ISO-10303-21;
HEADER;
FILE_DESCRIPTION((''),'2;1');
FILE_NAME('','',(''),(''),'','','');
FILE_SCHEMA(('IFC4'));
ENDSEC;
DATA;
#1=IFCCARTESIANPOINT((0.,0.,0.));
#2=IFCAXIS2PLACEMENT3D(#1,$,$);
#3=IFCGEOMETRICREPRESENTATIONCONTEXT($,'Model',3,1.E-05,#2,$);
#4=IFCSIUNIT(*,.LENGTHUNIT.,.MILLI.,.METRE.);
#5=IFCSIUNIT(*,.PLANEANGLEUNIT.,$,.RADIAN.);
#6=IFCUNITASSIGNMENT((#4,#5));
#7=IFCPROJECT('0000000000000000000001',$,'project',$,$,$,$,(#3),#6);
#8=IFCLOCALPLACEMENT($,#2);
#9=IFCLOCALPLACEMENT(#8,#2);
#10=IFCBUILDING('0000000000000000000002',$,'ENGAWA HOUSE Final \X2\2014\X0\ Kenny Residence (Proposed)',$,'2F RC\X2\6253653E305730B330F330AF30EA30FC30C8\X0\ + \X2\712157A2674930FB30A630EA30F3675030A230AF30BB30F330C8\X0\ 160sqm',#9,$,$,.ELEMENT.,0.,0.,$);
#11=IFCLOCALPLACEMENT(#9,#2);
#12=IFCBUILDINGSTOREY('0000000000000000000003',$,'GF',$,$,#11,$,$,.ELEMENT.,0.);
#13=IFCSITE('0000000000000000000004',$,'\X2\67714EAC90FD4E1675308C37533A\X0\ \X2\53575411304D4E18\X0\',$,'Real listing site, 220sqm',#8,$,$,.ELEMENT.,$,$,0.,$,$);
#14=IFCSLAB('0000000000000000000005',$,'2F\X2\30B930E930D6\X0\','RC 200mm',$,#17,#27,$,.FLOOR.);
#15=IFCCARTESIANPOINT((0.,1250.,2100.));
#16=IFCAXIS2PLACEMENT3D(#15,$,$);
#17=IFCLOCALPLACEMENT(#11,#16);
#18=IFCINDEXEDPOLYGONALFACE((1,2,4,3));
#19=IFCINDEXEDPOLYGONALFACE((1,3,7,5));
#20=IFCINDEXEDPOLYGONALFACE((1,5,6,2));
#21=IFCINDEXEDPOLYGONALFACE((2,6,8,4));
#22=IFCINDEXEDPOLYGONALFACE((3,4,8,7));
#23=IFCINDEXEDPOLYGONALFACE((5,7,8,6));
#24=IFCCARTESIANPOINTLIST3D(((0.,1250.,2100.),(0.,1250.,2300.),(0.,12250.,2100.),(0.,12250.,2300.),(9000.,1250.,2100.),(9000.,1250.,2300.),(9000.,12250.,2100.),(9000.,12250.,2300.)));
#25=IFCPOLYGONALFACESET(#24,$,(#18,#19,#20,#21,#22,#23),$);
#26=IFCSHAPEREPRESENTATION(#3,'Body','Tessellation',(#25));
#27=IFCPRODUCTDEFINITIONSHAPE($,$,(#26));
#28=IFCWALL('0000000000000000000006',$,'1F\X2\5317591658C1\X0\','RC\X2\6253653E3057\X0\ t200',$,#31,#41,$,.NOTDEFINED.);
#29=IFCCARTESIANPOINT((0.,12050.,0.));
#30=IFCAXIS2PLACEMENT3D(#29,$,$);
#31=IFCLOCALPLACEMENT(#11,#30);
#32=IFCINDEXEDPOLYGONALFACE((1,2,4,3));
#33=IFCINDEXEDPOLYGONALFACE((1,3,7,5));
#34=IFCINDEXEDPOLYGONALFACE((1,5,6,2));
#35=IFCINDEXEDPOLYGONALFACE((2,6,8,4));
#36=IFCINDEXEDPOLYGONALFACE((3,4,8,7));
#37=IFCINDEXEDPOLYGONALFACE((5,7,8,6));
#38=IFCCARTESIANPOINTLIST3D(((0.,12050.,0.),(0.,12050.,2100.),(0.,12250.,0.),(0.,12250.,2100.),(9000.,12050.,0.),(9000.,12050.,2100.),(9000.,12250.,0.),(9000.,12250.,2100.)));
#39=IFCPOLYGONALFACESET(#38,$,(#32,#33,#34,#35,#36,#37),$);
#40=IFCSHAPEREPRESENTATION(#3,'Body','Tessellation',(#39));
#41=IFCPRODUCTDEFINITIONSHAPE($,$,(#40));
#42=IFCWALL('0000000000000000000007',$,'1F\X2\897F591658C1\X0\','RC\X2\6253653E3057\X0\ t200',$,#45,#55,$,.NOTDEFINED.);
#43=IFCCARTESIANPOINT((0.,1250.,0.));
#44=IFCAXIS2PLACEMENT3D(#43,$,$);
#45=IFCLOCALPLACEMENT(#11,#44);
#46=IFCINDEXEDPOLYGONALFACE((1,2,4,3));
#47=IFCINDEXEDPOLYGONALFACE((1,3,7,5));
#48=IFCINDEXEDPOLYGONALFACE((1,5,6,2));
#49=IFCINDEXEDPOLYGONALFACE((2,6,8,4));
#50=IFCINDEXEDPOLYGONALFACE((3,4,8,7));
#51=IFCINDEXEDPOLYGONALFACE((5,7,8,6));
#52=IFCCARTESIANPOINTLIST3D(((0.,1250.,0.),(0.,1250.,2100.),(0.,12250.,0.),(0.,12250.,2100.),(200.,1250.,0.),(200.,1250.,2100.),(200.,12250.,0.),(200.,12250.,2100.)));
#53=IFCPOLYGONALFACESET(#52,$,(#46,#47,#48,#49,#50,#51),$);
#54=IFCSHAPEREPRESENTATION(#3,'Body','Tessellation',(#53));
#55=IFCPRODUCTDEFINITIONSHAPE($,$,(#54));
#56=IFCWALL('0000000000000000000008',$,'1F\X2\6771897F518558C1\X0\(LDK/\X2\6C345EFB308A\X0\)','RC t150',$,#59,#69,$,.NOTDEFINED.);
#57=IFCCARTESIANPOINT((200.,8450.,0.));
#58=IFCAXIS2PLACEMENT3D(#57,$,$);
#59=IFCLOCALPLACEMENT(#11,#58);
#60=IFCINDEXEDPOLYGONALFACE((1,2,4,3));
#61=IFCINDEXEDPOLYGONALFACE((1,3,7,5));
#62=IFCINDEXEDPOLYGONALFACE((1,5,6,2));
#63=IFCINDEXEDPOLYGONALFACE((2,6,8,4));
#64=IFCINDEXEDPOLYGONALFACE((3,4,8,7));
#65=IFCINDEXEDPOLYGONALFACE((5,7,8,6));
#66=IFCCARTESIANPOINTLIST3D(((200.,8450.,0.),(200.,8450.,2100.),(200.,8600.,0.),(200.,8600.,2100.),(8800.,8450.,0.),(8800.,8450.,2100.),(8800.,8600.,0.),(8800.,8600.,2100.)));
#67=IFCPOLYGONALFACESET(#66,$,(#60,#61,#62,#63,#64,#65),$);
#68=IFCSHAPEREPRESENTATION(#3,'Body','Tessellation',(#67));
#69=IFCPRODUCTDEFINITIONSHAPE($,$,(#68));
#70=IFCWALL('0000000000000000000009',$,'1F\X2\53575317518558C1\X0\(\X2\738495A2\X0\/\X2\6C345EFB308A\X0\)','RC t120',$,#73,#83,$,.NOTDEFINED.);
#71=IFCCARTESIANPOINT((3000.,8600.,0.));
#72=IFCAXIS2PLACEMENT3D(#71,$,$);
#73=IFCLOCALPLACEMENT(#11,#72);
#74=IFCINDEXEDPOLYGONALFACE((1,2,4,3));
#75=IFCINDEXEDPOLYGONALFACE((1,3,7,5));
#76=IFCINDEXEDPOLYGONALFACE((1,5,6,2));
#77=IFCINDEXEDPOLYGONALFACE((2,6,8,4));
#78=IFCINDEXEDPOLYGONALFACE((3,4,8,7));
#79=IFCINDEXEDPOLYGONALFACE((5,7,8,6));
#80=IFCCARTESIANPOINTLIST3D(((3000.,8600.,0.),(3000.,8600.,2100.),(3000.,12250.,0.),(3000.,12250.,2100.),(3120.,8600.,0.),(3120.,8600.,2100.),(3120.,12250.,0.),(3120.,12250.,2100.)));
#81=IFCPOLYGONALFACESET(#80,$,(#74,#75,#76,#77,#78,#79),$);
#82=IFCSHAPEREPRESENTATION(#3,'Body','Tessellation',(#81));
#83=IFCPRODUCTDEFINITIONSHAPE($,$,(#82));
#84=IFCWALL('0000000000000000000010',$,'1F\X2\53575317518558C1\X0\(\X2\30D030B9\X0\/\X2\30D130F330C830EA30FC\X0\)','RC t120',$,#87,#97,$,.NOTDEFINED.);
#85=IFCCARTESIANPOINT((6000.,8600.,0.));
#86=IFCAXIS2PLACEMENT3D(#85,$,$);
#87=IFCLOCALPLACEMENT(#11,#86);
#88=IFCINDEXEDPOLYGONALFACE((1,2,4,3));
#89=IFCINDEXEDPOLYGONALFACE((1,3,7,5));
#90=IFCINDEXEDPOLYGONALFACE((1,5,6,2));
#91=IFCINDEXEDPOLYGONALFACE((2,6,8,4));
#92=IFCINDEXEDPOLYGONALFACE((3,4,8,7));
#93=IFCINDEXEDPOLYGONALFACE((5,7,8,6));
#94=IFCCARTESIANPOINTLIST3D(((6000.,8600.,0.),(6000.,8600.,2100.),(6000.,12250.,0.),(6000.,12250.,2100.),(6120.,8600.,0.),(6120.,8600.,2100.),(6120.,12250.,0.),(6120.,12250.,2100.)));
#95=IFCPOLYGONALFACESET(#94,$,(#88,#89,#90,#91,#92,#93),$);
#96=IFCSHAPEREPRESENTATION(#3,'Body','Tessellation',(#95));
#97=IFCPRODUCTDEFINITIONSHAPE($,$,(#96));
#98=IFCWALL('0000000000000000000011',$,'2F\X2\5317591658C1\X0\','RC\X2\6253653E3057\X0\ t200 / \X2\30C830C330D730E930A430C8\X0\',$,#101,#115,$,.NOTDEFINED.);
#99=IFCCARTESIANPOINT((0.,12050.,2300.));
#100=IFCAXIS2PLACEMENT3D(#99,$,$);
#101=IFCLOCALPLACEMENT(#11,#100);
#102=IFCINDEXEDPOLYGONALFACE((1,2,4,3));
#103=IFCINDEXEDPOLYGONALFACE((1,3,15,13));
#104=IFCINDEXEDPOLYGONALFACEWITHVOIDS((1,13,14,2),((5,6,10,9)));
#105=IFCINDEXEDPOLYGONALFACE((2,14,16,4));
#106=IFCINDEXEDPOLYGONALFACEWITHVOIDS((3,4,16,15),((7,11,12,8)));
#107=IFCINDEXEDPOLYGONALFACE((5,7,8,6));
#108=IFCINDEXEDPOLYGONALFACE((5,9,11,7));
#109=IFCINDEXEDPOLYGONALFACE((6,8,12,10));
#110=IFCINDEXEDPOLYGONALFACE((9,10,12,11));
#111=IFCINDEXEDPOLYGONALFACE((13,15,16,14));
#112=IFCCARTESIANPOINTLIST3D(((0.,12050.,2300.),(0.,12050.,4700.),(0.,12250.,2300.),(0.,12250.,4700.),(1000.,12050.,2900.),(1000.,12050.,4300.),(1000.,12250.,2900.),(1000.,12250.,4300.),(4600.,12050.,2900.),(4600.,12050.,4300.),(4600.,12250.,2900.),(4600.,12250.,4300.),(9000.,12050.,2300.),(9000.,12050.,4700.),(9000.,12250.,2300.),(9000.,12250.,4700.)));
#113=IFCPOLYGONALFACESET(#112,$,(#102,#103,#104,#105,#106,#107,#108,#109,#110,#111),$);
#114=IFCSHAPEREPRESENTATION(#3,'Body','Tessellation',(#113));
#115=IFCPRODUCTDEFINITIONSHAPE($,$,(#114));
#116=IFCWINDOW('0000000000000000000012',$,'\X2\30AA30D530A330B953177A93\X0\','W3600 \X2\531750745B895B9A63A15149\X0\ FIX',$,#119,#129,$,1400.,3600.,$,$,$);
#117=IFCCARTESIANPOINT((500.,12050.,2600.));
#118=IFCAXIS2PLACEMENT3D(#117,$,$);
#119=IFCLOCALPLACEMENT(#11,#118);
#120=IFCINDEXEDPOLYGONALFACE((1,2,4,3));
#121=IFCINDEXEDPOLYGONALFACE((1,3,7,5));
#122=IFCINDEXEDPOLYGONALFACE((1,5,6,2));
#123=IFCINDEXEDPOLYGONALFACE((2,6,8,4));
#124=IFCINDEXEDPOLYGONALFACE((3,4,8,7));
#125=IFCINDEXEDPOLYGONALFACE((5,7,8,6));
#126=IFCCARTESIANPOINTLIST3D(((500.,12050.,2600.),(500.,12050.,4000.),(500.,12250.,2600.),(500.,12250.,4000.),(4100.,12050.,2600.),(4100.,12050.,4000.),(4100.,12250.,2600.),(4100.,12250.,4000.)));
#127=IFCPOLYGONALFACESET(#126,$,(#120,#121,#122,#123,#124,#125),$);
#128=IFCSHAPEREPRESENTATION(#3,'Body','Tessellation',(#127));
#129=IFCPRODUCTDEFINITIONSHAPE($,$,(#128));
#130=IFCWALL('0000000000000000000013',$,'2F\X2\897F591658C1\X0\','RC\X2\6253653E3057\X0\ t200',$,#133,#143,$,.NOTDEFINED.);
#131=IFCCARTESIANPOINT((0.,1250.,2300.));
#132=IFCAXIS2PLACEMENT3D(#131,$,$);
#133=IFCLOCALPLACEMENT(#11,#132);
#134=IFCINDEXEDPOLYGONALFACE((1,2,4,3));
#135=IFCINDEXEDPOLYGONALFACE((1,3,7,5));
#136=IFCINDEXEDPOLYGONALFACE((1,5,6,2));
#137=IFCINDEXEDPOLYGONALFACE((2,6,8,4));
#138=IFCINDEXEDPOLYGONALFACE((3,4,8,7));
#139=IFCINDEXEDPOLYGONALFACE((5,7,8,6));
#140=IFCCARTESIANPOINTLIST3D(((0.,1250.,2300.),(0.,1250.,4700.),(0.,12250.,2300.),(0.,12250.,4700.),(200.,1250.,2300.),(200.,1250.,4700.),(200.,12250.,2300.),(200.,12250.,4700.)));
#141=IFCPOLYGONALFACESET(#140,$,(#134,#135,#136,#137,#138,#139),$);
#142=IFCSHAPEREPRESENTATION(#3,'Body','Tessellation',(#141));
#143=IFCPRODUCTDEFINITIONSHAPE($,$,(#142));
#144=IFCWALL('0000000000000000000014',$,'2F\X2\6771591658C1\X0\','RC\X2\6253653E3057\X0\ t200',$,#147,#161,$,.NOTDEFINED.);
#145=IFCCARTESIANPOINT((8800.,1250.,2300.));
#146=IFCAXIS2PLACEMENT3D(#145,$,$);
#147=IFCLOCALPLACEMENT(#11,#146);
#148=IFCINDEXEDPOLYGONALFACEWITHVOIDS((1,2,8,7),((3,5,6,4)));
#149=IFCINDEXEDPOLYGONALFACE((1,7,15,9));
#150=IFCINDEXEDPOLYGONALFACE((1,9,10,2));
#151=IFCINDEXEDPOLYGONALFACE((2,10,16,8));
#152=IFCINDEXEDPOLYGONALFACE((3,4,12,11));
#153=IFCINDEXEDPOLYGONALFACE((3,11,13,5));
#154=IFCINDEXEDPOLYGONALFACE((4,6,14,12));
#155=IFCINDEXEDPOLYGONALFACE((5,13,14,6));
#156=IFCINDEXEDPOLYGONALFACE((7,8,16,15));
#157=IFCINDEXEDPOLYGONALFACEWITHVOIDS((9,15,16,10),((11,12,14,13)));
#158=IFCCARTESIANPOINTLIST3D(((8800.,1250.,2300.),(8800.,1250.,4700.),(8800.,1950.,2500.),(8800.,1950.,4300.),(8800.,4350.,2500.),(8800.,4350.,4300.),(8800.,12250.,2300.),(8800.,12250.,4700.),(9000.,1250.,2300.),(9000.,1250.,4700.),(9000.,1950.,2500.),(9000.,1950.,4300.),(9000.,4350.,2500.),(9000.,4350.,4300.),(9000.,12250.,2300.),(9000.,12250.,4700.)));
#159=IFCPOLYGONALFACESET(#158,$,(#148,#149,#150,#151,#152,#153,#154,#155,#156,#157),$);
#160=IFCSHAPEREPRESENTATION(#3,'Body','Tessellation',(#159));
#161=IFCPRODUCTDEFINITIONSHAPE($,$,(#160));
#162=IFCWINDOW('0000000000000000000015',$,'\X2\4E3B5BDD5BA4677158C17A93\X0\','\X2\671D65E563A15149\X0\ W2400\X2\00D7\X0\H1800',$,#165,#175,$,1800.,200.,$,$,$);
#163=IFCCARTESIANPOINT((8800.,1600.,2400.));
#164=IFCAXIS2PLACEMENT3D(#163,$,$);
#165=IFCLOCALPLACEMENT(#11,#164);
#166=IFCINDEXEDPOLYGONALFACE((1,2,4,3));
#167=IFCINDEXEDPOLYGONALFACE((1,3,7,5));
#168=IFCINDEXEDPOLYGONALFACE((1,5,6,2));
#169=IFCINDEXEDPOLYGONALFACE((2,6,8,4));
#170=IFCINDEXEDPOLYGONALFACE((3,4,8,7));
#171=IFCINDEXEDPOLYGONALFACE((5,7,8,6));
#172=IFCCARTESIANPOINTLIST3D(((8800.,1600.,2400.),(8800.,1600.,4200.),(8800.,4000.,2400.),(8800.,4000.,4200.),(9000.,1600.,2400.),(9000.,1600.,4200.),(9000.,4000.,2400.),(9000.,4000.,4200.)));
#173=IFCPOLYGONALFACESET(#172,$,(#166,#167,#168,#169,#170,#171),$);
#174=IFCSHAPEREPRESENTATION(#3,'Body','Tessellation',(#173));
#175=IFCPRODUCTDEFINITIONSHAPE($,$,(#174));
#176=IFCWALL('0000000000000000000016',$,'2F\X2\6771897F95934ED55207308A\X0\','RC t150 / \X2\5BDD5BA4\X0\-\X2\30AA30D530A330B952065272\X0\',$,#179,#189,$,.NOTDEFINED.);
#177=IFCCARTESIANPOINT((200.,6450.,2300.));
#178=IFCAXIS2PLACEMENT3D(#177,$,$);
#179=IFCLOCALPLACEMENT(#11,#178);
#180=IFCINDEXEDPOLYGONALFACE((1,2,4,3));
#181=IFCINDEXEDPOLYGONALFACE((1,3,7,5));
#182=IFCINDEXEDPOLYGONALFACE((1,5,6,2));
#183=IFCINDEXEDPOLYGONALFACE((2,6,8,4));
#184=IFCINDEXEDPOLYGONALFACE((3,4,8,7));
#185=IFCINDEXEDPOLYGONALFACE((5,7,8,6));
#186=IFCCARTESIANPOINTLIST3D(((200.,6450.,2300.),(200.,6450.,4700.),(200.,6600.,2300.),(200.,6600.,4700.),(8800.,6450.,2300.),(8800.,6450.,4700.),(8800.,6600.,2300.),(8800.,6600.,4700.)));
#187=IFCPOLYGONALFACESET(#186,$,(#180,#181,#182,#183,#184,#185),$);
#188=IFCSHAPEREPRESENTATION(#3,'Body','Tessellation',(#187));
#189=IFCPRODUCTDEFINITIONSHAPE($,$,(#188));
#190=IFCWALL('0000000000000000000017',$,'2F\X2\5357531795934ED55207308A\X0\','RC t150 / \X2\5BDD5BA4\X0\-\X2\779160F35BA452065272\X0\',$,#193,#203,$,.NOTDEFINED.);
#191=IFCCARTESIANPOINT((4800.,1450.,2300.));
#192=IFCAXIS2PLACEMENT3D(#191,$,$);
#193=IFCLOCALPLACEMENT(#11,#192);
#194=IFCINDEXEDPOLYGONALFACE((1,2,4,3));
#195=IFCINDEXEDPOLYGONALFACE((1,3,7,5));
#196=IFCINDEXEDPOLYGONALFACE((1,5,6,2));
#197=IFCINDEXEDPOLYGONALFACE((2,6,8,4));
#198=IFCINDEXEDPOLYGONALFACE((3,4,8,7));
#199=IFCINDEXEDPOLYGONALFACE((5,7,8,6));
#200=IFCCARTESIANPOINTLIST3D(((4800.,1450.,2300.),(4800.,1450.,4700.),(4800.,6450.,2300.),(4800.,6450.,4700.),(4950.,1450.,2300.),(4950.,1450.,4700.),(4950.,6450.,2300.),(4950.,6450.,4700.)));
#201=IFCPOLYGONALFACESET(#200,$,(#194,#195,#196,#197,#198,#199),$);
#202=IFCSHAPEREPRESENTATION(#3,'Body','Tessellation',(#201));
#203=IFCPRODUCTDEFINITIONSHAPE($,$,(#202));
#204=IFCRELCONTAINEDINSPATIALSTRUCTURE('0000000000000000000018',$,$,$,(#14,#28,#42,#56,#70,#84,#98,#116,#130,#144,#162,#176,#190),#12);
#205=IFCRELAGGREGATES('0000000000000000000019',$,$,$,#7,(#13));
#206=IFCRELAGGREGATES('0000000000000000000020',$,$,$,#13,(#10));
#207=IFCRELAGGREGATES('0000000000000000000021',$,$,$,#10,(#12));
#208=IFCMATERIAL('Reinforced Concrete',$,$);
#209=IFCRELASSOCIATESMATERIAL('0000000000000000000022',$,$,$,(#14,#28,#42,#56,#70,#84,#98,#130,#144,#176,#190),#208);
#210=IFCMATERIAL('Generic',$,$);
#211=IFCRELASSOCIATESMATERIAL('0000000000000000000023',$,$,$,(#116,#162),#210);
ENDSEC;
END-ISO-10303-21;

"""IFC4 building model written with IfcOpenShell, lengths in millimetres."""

from ifc_helpers import new_model, si_unit, frame, frame_2d, origin, place, context, project, spatial, rectangle, extrude, material, element, fill, save


model = new_model("IFC4")

# Units and contexts
model_context = context("Model", 3, precision=1e-05, world=origin())
ifc_project = project(units=[si_unit("LENGTHUNIT", "METRE", prefix="MILLI"), si_unit("PLANEANGLEUNIT", "RADIAN")], contexts=[model_context])

# Site, building, storey
site_placement = place(None, origin())
site = spatial("IfcSite", under=ifc_project, at=site_placement, Name="東京都世田谷区 南向き丘", ObjectType="Real listing site, 220sqm", CompositionType="ELEMENT", RefElevation=0.0)
building_placement = place(site_placement, origin())
building = spatial("IfcBuilding", under=site, at=building_placement, Name="ENGAWA HOUSE Final — Kenny Residence (Proposed)", ObjectType="2F RC打放しコンクリート + 無垢杉・ウリン材アクセント 160sqm", CompositionType="ELEMENT", ElevationOfRefHeight=0.0, ElevationOfTerrain=0.0)
storey_placement = place(building_placement, origin())
storey = spatial("IfcBuildingStorey", under=building, at=storey_placement, Name="GF", CompositionType="ELEMENT", Elevation=0.0)

# Slab
ifc_material_1 = material(Name="Reinforced Concrete")
ifc_material_2 = material(Name="Generic")
slab_1_placement = place(storey_placement, frame((0.0, 1250.0, 2100.0)))
element("IfcSlab", 1, at=slab_1_placement, inside=storey, material=ifc_material_1, Name="2Fスラブ", Description="RC 200mm", PredefinedType="FLOOR", context=model_context, shape_type="SweptSolid", body=[
    extrude(rectangle(XDim=9000.0, YDim=11000.0, at=frame_2d((4500.0, 5500.0))), frame((0.0, 1250.0, 2100.0)), (0.0, 0.0, 1.0), 200.0),
])

# Walls
wall_1_placement = place(storey_placement, frame((0.0, 12050.0, 0.0)))
element("IfcWall", 2, at=wall_1_placement, inside=storey, material=ifc_material_1, Name="1F北外壁", Description="RC打放し t200", PredefinedType="NOTDEFINED", context=model_context, shape_type="SweptSolid", body=[
    extrude(rectangle(XDim=9000.0, YDim=200.0, at=frame_2d((4500.0, 100.0))), frame((0.0, 12050.0, 0.0)), (0.0, 0.0, 1.0), 2100.0),
])
wall_2_placement = place(storey_placement, frame((0.0, 1250.0, 0.0)))
element("IfcWall", 3, at=wall_2_placement, inside=storey, material=ifc_material_1, Name="1F西外壁", Description="RC打放し t200", PredefinedType="NOTDEFINED", context=model_context, shape_type="SweptSolid", body=[
    extrude(rectangle(XDim=200.0, YDim=11000.0, at=frame_2d((100.0, 5500.0))), frame((0.0, 1250.0, 0.0)), (0.0, 0.0, 1.0), 2100.0),
])

# Walls
wall_3_placement = place(storey_placement, frame((200.0, 8450.0, 0.0)))
element("IfcWall", 4, at=wall_3_placement, inside=storey, material=ifc_material_1, Name="1F東西内壁(LDK/水廻り)", Description="RC t150", PredefinedType="NOTDEFINED", context=model_context, shape_type="SweptSolid", body=[
    extrude(rectangle(XDim=8600.0, YDim=150.0, at=frame_2d((4300.0, 75.0))), frame((200.0, 8450.0, 0.0)), (0.0, 0.0, 1.0), 2100.0),
])
wall_4_placement = place(storey_placement, frame((3000.0, 8600.0, 0.0)))
element("IfcWall", 5, at=wall_4_placement, inside=storey, material=ifc_material_1, Name="1F南北内壁(玄関/水廻り)", Description="RC t120", PredefinedType="NOTDEFINED", context=model_context, shape_type="SweptSolid", body=[
    extrude(rectangle(XDim=120.0, YDim=3650.0, at=frame_2d((60.0, 1825.0))), frame((3000.0, 8600.0, 0.0)), (0.0, 0.0, 1.0), 2100.0),
])
wall_5_placement = place(storey_placement, frame((6000.0, 8600.0, 0.0)))
element("IfcWall", 6, at=wall_5_placement, inside=storey, material=ifc_material_1, Name="1F南北内壁(バス/パントリー)", Description="RC t120", PredefinedType="NOTDEFINED", context=model_context, shape_type="SweptSolid", body=[
    extrude(rectangle(XDim=120.0, YDim=3650.0, at=frame_2d((60.0, 1825.0))), frame((6000.0, 8600.0, 0.0)), (0.0, 0.0, 1.0), 2100.0),
])

# Wall, opening, window
wall_6_placement = place(storey_placement, frame((0.0, 12050.0, 2300.0)))
wall_6 = element("IfcWall", 7, at=wall_6_placement, inside=storey, material=ifc_material_1, Name="2F北外壁", Description="RC打放し t200 / トップライト", PredefinedType="NOTDEFINED", context=model_context, shape_type="SweptSolid", body=[
    extrude(rectangle(XDim=9000.0, YDim=200.0, at=frame_2d((4500.0, 100.0))), frame((0.0, 12050.0, 2300.0)), (0.0, 0.0, 1.0), 2400.0),
])
opening_1_placement = place(storey_placement, frame((500.0, 12050.0, 2600.0)))
opening_1 = element("IfcOpeningElement", 8, at=opening_1_placement, cuts=wall_6, PredefinedType="NOTDEFINED", context=model_context, shape_type="SweptSolid", body=[
    extrude(rectangle(XDim=3600.0, YDim=200.0, at=frame_2d((1800.0, 100.0))), frame((500.0, 12050.0, 2600.0)), (0.0, 0.0, 1.0), 1400.0),
])
window_1_placement = place(storey_placement, frame((500.0, 12050.0, 2600.0)))
window_1 = element("IfcWindow", 9, at=window_1_placement, inside=storey, material=ifc_material_2, Name="オフィス北窓", Description="W3600 北側安定採光 FIX", OverallHeight=1400.0, OverallWidth=3600.0, context=model_context, shape_type="SweptSolid", body=[
    extrude(rectangle(XDim=3600.0, YDim=200.0, at=frame_2d((1800.0, 100.0))), frame((500.0, 12050.0, 2600.0)), (0.0, 0.0, 1.0), 1400.0),
])
fill(opening_1, window_1)

# Wall
wall_7_placement = place(storey_placement, frame((0.0, 1250.0, 2300.0)))
element("IfcWall", 10, at=wall_7_placement, inside=storey, material=ifc_material_1, Name="2F西外壁", Description="RC打放し t200", PredefinedType="NOTDEFINED", context=model_context, shape_type="SweptSolid", body=[
    extrude(rectangle(XDim=200.0, YDim=11000.0, at=frame_2d((100.0, 5500.0))), frame((0.0, 1250.0, 2300.0)), (0.0, 0.0, 1.0), 2400.0),
])

# Wall, opening, window
wall_8_placement = place(storey_placement, frame((8800.0, 1250.0, 2300.0)))
wall_8 = element("IfcWall", 11, at=wall_8_placement, inside=storey, material=ifc_material_1, Name="2F東外壁", Description="RC打放し t200", PredefinedType="NOTDEFINED", context=model_context, shape_type="SweptSolid", body=[
    extrude(rectangle(XDim=200.0, YDim=11000.0, at=frame_2d((100.0, 5500.0))), frame((8800.0, 1250.0, 2300.0)), (0.0, 0.0, 1.0), 2400.0),
])
opening_2_placement = place(storey_placement, frame((8800.0, 1600.0, 2400.0)))
opening_2 = element("IfcOpeningElement", 12, at=opening_2_placement, cuts=wall_8, PredefinedType="NOTDEFINED", context=model_context, shape_type="SweptSolid", body=[
    extrude(rectangle(XDim=200.0, YDim=2400.0, at=frame_2d((100.0, 1200.0))), frame((8800.0, 1600.0, 2400.0)), (0.0, 0.0, 1.0), 1800.0),
])
window_2_placement = place(storey_placement, frame((8800.0, 1600.0, 2400.0)))
window_2 = element("IfcWindow", 13, at=window_2_placement, inside=storey, material=ifc_material_2, Name="主寝室東壁窓", Description="朝日採光 W2400×H1800", OverallHeight=1800.0, OverallWidth=200.0, context=model_context, shape_type="SweptSolid", body=[
    extrude(rectangle(XDim=200.0, YDim=2400.0, at=frame_2d((100.0, 1200.0))), frame((8800.0, 1600.0, 2400.0)), (0.0, 0.0, 1.0), 1800.0),
])
fill(opening_2, window_2)

# Walls
wall_9_placement = place(storey_placement, frame((200.0, 6450.0, 2300.0)))
element("IfcWall", 14, at=wall_9_placement, inside=storey, material=ifc_material_1, Name="2F東西間仕切り", Description="RC t150 / 寝室-オフィス分割", PredefinedType="NOTDEFINED", context=model_context, shape_type="SweptSolid", body=[
    extrude(rectangle(XDim=8600.0, YDim=150.0, at=frame_2d((4300.0, 75.0))), frame((200.0, 6450.0, 2300.0)), (0.0, 0.0, 1.0), 2400.0),
])
wall_10_placement = place(storey_placement, frame((4800.0, 1450.0, 2300.0)))
element("IfcWall", 15, at=wall_10_placement, inside=storey, material=ifc_material_1, Name="2F南北間仕切り", Description="RC t150 / 寝室-瞑想室分割", PredefinedType="NOTDEFINED", context=model_context, shape_type="SweptSolid", body=[
    extrude(rectangle(XDim=150.0, YDim=5000.0, at=frame_2d((75.0, 2500.0))), frame((4800.0, 1450.0, 2300.0)), (0.0, 0.0, 1.0), 2400.0),
])

save(model, "model.ifc")
